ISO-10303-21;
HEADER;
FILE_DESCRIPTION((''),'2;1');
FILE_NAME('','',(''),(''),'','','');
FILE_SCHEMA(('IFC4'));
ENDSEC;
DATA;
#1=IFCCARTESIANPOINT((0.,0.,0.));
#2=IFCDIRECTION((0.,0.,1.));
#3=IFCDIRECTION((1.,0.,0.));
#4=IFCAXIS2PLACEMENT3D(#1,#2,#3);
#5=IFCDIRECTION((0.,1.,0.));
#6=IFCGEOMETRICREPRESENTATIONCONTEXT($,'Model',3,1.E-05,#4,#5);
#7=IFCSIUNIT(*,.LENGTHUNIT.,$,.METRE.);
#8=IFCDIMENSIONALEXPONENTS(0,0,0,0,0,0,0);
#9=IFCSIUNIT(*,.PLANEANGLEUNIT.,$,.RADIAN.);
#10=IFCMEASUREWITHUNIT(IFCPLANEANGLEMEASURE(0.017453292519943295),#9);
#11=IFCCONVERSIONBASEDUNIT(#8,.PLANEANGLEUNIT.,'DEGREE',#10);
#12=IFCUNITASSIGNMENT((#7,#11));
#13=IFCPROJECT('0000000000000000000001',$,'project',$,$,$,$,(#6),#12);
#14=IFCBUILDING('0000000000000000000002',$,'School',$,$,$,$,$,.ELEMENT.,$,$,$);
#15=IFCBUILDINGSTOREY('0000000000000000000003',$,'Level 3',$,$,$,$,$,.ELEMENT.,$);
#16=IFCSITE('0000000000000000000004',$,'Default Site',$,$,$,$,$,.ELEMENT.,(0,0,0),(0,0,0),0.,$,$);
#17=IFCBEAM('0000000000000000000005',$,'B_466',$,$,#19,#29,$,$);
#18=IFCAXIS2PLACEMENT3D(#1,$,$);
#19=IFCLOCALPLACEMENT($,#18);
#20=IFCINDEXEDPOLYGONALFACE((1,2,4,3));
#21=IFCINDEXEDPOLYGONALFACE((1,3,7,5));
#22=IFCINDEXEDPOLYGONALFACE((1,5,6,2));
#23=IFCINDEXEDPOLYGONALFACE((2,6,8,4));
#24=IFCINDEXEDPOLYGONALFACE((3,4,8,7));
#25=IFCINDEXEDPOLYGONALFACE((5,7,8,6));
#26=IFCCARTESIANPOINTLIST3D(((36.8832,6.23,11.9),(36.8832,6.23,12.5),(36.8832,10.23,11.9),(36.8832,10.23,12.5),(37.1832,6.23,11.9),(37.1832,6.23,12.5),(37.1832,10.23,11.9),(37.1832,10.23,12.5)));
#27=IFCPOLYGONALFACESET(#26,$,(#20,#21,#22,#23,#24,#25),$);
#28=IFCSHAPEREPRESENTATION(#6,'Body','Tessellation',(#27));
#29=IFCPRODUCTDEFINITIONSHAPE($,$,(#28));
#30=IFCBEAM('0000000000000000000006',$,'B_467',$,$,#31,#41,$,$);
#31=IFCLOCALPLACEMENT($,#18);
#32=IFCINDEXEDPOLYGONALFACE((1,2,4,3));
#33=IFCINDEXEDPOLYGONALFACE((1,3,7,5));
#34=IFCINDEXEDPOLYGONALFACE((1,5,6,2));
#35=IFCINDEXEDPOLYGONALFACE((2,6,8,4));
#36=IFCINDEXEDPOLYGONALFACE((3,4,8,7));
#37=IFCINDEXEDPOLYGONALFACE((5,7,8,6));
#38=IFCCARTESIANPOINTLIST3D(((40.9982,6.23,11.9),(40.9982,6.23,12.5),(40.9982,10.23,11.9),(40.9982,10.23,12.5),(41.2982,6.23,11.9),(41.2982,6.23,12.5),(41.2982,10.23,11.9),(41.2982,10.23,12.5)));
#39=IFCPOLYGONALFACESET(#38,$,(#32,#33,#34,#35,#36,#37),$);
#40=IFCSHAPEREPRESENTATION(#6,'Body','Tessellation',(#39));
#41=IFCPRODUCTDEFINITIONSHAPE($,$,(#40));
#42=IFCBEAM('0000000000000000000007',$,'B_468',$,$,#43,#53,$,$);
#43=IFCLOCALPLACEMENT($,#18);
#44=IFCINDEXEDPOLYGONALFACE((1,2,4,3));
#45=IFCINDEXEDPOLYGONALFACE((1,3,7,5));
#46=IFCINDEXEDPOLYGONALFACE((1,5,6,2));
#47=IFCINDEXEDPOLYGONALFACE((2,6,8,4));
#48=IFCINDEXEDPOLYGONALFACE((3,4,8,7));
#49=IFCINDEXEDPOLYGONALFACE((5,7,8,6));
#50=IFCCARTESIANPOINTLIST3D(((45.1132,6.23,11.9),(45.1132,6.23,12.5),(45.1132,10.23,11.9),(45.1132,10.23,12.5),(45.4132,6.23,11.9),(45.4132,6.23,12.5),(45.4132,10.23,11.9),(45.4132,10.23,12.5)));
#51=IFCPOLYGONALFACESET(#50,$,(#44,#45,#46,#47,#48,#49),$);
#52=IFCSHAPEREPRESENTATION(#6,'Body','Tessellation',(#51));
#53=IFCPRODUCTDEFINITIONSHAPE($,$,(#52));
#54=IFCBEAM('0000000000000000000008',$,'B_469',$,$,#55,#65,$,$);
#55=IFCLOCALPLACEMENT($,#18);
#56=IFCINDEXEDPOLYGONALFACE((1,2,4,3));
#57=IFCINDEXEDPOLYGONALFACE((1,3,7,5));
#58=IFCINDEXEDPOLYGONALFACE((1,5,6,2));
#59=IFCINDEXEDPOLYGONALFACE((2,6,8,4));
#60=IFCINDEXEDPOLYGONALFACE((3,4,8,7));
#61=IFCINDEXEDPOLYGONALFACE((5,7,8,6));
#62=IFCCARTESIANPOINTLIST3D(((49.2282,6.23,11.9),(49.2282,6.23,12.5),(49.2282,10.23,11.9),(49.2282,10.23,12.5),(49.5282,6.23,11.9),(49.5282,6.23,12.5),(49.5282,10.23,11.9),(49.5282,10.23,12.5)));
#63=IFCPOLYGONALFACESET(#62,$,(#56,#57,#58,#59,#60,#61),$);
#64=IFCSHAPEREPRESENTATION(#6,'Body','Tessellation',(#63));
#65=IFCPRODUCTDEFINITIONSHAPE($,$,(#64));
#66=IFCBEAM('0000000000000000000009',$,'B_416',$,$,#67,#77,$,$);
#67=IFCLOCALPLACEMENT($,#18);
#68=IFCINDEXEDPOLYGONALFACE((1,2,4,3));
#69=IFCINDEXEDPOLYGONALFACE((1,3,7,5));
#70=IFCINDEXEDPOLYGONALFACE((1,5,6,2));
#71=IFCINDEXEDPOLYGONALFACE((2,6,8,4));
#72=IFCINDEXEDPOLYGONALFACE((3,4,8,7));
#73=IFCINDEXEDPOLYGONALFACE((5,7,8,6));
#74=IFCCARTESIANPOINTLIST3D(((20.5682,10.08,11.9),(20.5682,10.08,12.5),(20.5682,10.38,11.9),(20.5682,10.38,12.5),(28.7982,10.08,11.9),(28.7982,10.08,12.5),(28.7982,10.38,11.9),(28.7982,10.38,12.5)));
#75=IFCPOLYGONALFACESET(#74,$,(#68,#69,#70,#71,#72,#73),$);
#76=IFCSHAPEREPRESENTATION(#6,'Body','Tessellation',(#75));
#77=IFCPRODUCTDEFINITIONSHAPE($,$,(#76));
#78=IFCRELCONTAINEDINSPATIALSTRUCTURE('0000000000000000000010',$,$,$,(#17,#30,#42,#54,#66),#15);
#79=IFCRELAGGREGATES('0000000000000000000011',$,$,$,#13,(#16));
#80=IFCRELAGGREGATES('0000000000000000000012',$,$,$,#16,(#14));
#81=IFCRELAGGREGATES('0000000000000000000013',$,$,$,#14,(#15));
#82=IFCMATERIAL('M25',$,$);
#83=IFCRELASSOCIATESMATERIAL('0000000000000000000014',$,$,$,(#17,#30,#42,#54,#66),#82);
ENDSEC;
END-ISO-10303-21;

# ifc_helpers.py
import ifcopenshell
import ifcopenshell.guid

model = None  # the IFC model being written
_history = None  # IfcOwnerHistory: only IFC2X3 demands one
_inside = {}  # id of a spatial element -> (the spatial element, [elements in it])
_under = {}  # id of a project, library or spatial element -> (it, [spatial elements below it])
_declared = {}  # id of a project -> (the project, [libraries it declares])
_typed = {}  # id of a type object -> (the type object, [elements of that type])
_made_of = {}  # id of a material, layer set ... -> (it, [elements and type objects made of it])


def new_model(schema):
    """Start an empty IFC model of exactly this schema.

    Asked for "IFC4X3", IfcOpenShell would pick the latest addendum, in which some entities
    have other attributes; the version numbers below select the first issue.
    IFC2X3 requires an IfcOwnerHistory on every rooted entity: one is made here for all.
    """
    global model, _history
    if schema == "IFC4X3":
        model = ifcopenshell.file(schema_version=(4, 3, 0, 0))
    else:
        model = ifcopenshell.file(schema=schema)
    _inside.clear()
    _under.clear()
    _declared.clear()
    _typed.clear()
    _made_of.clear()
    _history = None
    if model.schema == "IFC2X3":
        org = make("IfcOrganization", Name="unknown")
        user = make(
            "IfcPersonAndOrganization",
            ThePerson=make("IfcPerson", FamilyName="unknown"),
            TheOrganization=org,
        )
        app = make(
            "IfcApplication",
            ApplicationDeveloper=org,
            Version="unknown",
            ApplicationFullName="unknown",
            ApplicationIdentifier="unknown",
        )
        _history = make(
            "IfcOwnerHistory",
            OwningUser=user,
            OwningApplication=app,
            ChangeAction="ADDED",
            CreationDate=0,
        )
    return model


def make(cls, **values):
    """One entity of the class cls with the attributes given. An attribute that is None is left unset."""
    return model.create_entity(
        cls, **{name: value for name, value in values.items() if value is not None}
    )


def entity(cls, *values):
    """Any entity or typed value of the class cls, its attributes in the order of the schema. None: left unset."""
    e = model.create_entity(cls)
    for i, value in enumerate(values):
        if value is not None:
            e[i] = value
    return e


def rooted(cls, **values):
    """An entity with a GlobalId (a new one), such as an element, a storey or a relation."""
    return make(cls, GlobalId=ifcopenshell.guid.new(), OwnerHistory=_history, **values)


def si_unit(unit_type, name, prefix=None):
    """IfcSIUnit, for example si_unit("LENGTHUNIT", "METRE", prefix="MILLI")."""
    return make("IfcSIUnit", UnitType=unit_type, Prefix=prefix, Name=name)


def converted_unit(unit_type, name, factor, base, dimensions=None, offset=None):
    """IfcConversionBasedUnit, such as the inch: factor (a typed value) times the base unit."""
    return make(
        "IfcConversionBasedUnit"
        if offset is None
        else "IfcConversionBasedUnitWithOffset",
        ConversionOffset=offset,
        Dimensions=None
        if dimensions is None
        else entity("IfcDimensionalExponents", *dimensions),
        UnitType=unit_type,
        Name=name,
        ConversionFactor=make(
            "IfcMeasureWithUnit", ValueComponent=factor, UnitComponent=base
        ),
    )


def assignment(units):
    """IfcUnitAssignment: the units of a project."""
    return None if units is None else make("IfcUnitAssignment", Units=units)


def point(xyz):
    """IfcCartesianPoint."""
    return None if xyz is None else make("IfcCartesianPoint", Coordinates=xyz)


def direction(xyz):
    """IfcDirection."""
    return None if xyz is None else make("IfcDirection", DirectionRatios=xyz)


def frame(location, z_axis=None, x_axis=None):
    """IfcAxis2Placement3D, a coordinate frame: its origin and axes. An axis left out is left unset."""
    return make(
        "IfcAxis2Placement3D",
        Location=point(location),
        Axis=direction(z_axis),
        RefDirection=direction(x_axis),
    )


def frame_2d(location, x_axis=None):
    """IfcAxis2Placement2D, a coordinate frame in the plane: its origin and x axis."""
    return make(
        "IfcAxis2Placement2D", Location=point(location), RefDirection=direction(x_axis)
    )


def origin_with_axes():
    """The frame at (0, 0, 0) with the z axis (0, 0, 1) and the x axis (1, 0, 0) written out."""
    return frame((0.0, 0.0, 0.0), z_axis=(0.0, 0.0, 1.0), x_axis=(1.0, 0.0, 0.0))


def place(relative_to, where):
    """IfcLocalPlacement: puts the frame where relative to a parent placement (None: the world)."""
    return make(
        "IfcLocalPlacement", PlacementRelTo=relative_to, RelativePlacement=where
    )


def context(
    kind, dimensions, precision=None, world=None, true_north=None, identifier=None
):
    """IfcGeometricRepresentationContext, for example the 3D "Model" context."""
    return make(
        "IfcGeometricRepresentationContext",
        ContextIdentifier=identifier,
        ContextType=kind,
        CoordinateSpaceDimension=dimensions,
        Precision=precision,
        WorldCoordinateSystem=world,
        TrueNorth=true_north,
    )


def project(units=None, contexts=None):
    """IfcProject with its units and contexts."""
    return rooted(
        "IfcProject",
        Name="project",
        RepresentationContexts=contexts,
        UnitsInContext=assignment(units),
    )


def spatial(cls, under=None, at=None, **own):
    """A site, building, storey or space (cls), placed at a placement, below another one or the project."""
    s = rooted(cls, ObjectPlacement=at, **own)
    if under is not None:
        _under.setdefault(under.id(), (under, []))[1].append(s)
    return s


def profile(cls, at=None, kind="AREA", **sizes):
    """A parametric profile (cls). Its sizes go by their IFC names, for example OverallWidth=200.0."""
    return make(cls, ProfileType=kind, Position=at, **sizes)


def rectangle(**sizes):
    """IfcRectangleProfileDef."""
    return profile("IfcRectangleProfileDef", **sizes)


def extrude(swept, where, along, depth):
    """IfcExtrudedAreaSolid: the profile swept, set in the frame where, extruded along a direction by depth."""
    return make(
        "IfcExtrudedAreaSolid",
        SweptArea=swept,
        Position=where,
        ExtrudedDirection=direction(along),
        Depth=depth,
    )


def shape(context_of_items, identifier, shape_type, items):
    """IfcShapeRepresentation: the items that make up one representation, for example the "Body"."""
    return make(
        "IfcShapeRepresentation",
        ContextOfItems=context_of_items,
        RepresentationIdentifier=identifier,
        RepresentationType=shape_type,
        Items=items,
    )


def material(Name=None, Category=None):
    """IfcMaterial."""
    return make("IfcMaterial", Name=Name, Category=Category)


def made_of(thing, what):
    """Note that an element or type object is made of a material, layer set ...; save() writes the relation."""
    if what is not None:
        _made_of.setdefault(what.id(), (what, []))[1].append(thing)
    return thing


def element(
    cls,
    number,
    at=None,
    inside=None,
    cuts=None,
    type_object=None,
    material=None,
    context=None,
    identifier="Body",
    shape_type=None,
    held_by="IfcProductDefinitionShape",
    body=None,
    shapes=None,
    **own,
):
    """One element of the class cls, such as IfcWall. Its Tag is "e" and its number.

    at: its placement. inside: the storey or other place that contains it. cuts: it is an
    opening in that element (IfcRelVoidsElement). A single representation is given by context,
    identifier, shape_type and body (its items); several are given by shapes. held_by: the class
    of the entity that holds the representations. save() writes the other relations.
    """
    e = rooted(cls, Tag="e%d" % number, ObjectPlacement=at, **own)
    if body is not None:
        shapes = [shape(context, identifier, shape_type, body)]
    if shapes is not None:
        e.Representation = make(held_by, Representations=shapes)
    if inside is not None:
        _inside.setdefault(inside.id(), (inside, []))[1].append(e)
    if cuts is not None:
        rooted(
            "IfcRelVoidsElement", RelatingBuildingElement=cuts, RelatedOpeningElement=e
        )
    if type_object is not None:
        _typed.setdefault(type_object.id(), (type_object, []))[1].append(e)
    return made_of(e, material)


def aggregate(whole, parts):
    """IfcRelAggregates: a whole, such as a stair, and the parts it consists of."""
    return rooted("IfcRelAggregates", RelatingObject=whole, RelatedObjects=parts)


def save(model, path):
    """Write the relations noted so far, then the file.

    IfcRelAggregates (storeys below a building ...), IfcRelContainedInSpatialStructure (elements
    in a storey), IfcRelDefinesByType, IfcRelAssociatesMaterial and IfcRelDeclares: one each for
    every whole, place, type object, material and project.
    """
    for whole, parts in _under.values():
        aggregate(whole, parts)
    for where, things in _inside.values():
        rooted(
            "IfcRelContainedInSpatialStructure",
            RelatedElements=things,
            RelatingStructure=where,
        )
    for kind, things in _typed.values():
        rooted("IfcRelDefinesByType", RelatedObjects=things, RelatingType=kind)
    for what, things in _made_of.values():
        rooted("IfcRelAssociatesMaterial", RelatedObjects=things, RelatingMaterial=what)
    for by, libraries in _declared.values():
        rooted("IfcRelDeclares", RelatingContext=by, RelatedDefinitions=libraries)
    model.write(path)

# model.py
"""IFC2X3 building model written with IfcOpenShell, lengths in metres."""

from ifc_helpers import new_model, entity, si_unit, converted_unit, direction, frame, frame_2d, origin_with_axes, place, context, project, spatial, rectangle, extrude, material, element, save


model = new_model("IFC2X3")

# Units and contexts
model_context = context("Model", 3, precision=1e-05, world=origin_with_axes(), true_north=direction((0.0, 1.0, 0.0)))
ifc_project = project(units=[si_unit("LENGTHUNIT", "METRE"), converted_unit("PLANEANGLEUNIT", "DEGREE", entity("IfcPlaneAngleMeasure", 0.017453292519943295), si_unit("PLANEANGLEUNIT", "RADIAN"), dimensions=[0, 0, 0, 0, 0, 0, 0])], contexts=[model_context])

# Site, building, storey
site = spatial("IfcSite", under=ifc_project, Name="Default Site", CompositionType="ELEMENT", RefLatitude=(0, 0, 0), RefLongitude=(0, 0, 0), RefElevation=0.0)
building = spatial("IfcBuilding", under=site, Name="School", CompositionType="ELEMENT")
storey = spatial("IfcBuildingStorey", under=building, Name="Level 3", CompositionType="ELEMENT")

# Shared definitions
ifc_material = material(Name="M25")
placement = place(None, origin_with_axes())

# Beams
element("IfcBeam", 1, at=placement, inside=storey, material=ifc_material, Name="B_466", context=model_context, shape_type="SweptSolid", body=[
    extrude(rectangle(XDim=0.3, YDim=0.6, at=frame_2d((0.0, 0.0), x_axis=(0.0, 1.0, 0.0))), frame((37.0332, 6.23, 12.2), z_axis=(0.0, 1.0, 0.0), x_axis=(0.0, 0.0, -1.0)), (0.0, 0.0, 1.0), 4.0),
])
element("IfcBeam", 2, at=placement, inside=storey, material=ifc_material, Name="B_467", context=model_context, shape_type="SweptSolid", body=[
    extrude(rectangle(XDim=0.3, YDim=0.6, at=frame_2d((0.0, 0.0), x_axis=(0.0, 1.0, 0.0))), frame((41.1482, 6.23, 12.2), z_axis=(0.0, 1.0, 0.0), x_axis=(0.0, 0.0, -1.0)), (0.0, 0.0, 1.0), 4.0),
])
element("IfcBeam", 3, at=placement, inside=storey, material=ifc_material, Name="B_468", context=model_context, shape_type="SweptSolid", body=[
    extrude(rectangle(XDim=0.3, YDim=0.6, at=frame_2d((0.0, 0.0), x_axis=(0.0, 1.0, 0.0))), frame((45.2632, 6.23, 12.2), z_axis=(0.0, 1.0, 0.0), x_axis=(0.0, 0.0, -1.0)), (0.0, 0.0, 1.0), 4.0),
])
element("IfcBeam", 4, at=placement, inside=storey, material=ifc_material, Name="B_469", context=model_context, shape_type="SweptSolid", body=[
    extrude(rectangle(XDim=0.3, YDim=0.6, at=frame_2d((0.0, 0.0), x_axis=(0.0, 1.0, 0.0))), frame((49.3782, 6.23, 12.2), z_axis=(0.0, 1.0, 0.0), x_axis=(0.0, 0.0, -1.0)), (0.0, 0.0, 1.0), 4.0),
])
element("IfcBeam", 5, at=placement, inside=storey, material=ifc_material, Name="B_416", context=model_context, shape_type="SweptSolid", body=[
    extrude(rectangle(XDim=0.3, YDim=0.6, at=frame_2d((0.0, 0.0), x_axis=(0.0, 1.0, 0.0))), frame((20.5682, 10.23, 12.2), z_axis=(1.0, 0.0, 0.0), x_axis=(0.0, 0.0, -1.0)), (0.0, 0.0, 1.0), 8.23),
])

save(model, "model.ifc")
